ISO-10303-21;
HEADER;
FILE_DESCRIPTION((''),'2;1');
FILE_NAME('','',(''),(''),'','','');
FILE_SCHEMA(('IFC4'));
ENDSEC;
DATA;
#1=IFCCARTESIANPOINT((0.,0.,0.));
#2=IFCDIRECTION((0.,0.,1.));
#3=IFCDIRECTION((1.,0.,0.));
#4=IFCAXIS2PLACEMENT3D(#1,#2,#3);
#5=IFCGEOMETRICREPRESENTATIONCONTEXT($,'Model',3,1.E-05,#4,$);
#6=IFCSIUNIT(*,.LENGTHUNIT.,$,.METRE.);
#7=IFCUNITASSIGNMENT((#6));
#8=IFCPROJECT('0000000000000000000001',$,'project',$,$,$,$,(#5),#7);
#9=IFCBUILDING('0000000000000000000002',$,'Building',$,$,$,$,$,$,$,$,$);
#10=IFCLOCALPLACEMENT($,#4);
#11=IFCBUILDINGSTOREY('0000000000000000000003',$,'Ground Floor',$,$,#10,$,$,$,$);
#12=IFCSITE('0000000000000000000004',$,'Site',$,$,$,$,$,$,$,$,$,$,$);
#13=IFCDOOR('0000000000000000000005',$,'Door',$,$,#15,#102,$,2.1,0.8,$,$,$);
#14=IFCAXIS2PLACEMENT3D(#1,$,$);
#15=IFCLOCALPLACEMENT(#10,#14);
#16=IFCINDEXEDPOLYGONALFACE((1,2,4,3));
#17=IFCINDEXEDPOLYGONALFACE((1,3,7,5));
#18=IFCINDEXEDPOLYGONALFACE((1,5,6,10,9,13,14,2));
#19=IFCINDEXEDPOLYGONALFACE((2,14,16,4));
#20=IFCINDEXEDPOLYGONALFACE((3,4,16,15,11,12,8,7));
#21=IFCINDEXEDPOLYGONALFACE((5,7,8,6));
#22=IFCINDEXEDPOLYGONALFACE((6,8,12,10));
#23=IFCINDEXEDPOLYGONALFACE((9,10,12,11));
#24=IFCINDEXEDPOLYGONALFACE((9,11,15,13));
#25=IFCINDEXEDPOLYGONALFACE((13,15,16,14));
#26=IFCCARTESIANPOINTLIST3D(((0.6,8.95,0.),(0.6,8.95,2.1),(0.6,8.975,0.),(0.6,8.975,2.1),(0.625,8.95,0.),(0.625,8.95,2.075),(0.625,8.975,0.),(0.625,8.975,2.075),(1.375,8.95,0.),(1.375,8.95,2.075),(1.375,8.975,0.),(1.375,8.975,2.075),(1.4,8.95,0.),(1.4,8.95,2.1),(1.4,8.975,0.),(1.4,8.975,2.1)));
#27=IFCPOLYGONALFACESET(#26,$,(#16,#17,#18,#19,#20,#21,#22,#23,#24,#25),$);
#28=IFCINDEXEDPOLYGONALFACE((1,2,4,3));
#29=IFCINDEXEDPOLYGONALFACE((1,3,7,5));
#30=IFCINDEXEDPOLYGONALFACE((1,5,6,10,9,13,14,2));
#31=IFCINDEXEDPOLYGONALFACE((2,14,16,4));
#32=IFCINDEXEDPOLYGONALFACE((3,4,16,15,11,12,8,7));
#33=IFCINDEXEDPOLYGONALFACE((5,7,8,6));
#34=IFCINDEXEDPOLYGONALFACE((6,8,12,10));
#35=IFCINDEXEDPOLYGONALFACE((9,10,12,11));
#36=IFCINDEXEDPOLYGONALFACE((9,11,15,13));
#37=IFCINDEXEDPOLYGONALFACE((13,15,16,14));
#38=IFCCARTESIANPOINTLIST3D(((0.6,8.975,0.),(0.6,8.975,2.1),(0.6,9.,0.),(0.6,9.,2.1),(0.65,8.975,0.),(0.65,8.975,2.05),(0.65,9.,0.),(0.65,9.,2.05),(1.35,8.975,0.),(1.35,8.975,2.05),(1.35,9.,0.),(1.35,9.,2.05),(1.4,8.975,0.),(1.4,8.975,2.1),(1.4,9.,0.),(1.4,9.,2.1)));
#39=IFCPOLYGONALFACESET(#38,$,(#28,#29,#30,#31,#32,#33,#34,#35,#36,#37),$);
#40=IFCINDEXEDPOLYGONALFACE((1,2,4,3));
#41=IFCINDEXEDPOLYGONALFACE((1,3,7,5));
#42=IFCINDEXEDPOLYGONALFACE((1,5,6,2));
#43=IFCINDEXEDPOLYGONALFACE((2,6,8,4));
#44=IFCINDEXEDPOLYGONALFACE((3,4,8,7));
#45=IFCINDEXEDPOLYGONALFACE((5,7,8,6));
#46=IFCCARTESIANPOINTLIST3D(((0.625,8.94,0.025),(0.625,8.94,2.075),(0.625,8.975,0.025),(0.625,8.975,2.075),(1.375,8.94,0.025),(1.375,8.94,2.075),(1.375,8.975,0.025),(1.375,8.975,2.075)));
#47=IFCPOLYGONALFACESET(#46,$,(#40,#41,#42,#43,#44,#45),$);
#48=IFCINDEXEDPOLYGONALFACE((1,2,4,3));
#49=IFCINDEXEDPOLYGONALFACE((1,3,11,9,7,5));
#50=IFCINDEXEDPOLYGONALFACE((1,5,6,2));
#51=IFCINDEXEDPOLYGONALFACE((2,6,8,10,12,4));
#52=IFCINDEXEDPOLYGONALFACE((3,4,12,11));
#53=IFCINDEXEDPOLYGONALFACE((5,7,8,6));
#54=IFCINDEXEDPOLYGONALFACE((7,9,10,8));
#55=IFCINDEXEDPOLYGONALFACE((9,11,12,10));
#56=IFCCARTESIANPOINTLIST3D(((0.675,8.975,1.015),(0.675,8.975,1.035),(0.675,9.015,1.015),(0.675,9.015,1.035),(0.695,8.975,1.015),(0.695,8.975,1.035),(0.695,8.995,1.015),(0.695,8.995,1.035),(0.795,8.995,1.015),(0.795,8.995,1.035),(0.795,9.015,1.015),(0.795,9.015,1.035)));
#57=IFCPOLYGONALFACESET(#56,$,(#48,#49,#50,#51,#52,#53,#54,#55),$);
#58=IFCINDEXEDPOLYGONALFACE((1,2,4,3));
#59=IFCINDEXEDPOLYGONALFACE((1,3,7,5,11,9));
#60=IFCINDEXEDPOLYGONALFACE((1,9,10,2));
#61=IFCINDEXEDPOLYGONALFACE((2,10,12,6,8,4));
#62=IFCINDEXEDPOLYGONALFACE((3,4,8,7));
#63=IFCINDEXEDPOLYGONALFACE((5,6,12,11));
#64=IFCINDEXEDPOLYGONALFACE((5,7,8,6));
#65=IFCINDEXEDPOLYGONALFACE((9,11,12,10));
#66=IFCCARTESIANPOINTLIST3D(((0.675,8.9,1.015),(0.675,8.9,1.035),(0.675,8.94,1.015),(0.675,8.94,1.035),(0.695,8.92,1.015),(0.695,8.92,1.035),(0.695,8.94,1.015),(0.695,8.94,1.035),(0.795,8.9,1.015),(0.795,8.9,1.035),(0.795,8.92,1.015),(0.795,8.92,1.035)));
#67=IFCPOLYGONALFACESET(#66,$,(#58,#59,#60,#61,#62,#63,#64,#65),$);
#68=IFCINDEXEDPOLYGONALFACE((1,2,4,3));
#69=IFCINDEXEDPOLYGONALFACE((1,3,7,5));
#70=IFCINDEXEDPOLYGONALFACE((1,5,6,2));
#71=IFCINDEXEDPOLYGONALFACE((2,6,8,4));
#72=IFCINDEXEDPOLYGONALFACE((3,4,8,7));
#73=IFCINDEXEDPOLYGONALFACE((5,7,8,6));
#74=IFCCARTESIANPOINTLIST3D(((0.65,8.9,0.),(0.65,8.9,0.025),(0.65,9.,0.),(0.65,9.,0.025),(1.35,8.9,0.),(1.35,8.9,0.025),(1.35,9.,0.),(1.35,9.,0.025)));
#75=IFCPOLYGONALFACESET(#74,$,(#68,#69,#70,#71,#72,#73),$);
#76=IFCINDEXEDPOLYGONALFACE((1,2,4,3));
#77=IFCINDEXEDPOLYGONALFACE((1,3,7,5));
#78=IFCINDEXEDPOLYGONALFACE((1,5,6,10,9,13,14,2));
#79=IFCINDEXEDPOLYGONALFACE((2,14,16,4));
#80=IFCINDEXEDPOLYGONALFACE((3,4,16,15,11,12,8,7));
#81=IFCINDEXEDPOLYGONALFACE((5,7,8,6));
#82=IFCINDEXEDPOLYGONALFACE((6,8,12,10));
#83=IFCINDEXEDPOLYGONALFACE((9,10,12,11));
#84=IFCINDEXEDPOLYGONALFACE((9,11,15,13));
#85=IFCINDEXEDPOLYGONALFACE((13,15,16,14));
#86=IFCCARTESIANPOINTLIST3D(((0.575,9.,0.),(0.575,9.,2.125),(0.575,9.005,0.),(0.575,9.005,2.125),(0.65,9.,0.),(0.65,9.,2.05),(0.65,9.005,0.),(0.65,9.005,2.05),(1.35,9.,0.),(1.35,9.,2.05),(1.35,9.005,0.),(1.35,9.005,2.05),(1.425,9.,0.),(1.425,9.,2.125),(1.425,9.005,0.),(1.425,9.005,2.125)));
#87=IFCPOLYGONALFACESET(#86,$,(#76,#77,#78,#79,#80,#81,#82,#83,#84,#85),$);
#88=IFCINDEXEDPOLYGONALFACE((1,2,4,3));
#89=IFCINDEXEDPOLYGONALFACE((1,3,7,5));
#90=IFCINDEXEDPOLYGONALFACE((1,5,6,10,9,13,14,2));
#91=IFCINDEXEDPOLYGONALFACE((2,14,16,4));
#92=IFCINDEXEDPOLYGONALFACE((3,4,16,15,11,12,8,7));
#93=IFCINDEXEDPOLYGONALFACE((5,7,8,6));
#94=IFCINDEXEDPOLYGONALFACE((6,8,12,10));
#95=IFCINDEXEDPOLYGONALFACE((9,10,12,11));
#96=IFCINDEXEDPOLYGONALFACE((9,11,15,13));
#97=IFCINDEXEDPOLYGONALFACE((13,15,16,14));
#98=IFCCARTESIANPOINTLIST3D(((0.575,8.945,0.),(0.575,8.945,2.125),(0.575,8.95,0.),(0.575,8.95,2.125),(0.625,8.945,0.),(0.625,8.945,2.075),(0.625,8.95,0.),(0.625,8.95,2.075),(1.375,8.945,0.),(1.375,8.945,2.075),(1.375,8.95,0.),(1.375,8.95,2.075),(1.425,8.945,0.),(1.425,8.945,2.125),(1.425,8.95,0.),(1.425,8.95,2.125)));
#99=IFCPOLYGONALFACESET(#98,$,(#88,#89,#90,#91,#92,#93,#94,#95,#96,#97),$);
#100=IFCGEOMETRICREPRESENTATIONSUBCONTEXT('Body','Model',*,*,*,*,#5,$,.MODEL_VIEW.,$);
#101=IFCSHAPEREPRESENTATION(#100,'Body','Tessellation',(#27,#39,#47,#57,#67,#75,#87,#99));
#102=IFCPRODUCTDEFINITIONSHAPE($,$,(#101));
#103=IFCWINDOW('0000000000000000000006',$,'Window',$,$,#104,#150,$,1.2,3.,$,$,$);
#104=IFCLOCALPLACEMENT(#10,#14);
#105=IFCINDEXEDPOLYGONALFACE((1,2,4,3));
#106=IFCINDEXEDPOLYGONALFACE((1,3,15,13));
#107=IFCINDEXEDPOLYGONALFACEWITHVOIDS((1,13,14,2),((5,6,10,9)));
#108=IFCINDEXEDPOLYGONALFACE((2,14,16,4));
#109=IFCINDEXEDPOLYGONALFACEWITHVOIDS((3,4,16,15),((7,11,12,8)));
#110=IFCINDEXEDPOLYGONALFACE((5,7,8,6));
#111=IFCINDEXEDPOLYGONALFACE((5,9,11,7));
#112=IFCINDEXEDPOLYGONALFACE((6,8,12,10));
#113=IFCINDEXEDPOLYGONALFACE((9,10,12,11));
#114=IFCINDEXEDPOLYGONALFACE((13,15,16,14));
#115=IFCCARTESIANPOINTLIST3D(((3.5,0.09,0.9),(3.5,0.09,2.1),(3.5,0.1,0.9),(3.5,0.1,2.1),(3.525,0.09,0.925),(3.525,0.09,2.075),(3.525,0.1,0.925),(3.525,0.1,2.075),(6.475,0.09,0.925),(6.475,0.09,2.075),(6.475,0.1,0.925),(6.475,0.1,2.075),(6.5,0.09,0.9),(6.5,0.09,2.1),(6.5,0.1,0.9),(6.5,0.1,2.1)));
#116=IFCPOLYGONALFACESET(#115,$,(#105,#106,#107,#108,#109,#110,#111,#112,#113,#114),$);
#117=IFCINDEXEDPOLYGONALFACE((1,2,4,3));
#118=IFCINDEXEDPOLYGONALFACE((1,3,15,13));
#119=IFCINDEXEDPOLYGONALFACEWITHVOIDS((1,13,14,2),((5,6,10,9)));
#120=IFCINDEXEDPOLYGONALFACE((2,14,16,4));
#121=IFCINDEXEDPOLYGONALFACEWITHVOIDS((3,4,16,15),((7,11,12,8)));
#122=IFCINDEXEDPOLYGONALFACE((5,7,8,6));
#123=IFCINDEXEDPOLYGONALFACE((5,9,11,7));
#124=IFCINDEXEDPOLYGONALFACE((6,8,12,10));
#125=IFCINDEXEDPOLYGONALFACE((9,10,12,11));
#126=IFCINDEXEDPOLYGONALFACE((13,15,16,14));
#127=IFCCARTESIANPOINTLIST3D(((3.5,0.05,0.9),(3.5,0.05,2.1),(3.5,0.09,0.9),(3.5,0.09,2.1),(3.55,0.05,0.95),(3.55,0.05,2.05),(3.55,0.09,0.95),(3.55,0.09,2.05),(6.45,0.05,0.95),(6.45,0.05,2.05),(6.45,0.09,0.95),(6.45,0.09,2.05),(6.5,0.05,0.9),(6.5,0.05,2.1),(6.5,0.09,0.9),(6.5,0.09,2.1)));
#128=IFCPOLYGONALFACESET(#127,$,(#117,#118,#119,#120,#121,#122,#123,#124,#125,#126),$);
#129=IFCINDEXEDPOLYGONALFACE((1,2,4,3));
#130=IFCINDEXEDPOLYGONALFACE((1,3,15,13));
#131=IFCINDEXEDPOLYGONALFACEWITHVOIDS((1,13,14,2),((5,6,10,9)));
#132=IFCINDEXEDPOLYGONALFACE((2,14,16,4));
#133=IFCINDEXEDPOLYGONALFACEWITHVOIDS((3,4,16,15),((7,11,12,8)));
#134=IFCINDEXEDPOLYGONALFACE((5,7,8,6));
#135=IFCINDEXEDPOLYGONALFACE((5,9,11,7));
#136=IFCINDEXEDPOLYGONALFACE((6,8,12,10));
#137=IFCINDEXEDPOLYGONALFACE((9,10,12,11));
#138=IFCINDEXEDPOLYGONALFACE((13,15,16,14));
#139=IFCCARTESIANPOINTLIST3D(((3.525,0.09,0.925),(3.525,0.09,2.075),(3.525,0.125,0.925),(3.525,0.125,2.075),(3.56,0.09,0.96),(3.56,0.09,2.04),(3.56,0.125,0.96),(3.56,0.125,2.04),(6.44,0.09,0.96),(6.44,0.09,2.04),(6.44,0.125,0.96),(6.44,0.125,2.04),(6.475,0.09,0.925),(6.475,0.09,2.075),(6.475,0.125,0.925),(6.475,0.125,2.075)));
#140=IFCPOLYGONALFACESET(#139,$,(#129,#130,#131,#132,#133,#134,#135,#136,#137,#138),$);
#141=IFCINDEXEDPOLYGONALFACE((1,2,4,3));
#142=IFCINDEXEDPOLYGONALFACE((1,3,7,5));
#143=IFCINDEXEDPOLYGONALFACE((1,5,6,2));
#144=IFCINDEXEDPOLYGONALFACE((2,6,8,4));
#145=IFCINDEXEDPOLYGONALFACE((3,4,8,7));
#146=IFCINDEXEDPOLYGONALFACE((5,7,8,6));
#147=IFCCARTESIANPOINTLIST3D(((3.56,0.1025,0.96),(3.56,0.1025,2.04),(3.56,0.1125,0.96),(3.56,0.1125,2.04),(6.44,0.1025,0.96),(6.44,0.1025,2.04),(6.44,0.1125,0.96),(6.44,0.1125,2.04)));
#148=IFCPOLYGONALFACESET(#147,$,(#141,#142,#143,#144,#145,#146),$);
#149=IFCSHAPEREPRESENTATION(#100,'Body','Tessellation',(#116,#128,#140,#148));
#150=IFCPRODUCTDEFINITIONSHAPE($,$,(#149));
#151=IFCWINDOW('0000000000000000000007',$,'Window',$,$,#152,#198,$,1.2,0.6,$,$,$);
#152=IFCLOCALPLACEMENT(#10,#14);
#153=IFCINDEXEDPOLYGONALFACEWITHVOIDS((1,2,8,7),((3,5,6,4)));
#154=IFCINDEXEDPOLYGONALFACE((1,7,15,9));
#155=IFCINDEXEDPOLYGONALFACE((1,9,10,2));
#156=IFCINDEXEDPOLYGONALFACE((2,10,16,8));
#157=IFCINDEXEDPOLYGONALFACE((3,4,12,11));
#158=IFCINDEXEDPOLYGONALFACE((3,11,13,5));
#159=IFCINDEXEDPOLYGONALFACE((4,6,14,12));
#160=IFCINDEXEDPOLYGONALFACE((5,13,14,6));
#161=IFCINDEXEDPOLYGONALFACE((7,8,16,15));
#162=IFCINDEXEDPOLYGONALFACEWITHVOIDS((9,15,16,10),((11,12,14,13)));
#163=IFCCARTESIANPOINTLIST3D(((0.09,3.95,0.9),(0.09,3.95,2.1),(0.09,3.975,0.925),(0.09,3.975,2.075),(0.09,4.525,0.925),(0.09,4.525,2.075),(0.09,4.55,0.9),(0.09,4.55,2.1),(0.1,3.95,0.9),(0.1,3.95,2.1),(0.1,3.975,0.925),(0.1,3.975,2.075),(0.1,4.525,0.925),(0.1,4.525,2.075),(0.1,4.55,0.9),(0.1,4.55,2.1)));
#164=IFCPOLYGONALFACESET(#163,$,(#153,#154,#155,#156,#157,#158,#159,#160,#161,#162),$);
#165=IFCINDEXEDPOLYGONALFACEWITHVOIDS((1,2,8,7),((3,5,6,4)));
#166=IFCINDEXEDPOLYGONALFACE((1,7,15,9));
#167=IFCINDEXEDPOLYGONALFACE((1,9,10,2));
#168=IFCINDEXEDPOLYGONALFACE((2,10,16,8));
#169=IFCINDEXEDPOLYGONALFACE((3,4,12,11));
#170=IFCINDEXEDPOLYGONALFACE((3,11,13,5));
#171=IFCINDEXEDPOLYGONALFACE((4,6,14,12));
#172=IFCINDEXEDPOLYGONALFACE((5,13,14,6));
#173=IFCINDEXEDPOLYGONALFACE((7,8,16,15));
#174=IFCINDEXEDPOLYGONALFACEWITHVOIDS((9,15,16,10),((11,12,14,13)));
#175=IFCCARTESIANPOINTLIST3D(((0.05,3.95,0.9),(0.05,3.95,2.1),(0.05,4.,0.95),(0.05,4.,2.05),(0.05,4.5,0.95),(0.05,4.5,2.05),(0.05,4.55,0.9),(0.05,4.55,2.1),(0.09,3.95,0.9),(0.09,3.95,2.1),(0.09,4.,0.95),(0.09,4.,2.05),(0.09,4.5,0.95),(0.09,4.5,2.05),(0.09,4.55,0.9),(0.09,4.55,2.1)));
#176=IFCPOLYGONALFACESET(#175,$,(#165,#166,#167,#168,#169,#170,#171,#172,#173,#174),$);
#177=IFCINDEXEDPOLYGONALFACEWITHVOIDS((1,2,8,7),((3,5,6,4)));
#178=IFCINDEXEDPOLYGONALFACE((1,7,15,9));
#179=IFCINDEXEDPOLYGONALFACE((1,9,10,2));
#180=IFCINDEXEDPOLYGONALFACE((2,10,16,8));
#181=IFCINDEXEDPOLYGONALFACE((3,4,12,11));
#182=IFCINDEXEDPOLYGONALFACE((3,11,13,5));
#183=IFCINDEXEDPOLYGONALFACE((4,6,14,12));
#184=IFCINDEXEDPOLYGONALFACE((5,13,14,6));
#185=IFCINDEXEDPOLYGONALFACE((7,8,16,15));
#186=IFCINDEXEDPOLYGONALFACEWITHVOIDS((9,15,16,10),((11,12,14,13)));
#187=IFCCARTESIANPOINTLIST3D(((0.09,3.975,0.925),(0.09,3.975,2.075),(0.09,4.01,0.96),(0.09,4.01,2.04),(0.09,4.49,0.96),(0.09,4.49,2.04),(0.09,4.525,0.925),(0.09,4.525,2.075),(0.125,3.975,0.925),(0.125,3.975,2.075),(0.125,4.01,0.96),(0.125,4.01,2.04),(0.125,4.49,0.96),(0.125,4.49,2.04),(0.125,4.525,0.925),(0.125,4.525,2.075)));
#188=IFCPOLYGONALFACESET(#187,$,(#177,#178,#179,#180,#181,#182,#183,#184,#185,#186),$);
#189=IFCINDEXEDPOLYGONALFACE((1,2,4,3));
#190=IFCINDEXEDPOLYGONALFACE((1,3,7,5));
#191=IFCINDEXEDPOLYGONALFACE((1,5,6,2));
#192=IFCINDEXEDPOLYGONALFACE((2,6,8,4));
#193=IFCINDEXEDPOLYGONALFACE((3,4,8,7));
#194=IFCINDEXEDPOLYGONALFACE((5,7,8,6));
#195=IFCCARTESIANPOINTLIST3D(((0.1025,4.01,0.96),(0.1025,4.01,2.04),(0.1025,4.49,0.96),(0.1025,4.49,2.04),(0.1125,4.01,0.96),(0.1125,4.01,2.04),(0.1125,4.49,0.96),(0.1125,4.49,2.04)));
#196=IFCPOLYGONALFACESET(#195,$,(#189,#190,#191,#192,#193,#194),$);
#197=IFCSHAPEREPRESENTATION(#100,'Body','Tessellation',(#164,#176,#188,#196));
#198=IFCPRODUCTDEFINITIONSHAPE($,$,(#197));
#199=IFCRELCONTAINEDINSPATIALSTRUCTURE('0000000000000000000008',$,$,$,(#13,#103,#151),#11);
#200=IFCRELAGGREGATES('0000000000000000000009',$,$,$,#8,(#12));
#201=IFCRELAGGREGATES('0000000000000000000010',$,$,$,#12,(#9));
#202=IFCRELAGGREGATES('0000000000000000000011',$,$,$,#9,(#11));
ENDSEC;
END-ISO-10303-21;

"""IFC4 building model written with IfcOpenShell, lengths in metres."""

from ifc_helpers import new_model, si_unit, frame, origin_with_axes, place, context, subcontext, project, spatial, line, indexed_curve, outline, extrude, element, save


model = new_model("IFC4")

# Units and contexts
model_context = context("Model", 3, precision=1e-05, world=origin_with_axes())
body_context = subcontext(model_context, "Body", "Model", "MODEL_VIEW")
ifc_project = project(units=[si_unit("LENGTHUNIT", "METRE")], contexts=[model_context])

# Site, building, storey
site = spatial("IfcSite", under=ifc_project, Name="Site")
building = spatial("IfcBuilding", under=site, Name="Building")
storey_placement = place(None, origin_with_axes())
storey = spatial("IfcBuildingStorey", under=building, at=storey_placement, Name="Ground Floor")

# Door
door_1_placement = place(storey_placement, frame((1.4, 9.0, 0.0), z_axis=(0.0, 0.0, 1.0), x_axis=(-1.0, 0.0, 0.0)))
element("IfcDoor", 1, at=door_1_placement, inside=storey, Name="Door", OverallHeight=2.1, OverallWidth=0.8, context=body_context, shape_type="SweptSolid", body=[
    extrude(outline(indexed_curve([(0.0, 0.0), (0.0, 2.1), (0.8, 2.1), (0.8, 0.0), (0.775, 0.0), (0.775, 2.075), (0.025, 2.075), (0.025, 0.0)], segments=[line(1, 2, 3, 4, 5, 6, 7, 8, 1)])), frame((0.0, 0.025, 0.0), z_axis=(0.0, -1.0, 0.0), x_axis=(1.0, 0.0, 0.0)), (0.0, 0.0, -1.0), 0.025),
    extrude(outline(indexed_curve([(0.0, 0.0), (0.0, 2.1), (0.8, 2.1), (0.8, 0.0), (0.75, 0.0), (0.75, 2.05), (0.05, 2.05), (0.05, 0.0)], segments=[line(1, 2, 3, 4, 5, 6, 7, 8, 1)])), frame((0.0, 0.0, 0.0), z_axis=(0.0, -1.0, 0.0), x_axis=(1.0, 0.0, 0.0)), (0.0, 0.0, -1.0), 0.025),
    extrude(outline(indexed_curve([(0.0, 0.0), (0.75, 0.0), (0.75, 0.035), (0.0, 0.035)], segments=[line(1, 2, 3, 4, 1)])), frame((0.025, 0.025, 0.025), z_axis=(0.0, 0.0, 1.0), x_axis=(1.0, 0.0, 0.0)), (0.0, 0.0, 1.0), 2.05),
    extrude(outline(indexed_curve([(0.0, 0.0), (0.0, -0.04), (-0.12, -0.04), (-0.12, -0.02), (-0.02, -0.02), (-0.02, 0.0)], segments=[line(1, 2, 3, 4, 5, 6, 1)])), frame((0.725, 0.025, 1.015), z_axis=(0.0, 0.0, 1.0), x_axis=(1.0, 0.0, 0.0)), (0.0, 0.0, 1.0), 0.02),
    extrude(outline(indexed_curve([(0.0, 0.0), (0.0, 0.04), (-0.12, 0.04), (-0.12, 0.02), (-0.02, 0.02), (-0.02, 0.0)], segments=[line(1, 2, 3, 4, 5, 6, 1)])), frame((0.725, 0.06, 1.015), z_axis=(0.0, 0.0, 1.0), x_axis=(1.0, 0.0, 0.0)), (0.0, 0.0, 1.0), 0.02),
    extrude(outline(indexed_curve([(0.0, 0.0), (0.7, 0.0), (0.7, 0.1), (0.0, 0.1)], segments=[line(1, 2, 3, 4, 1)])), frame((0.05, 0.0, 0.0), z_axis=(0.0, 0.0, 1.0), x_axis=(1.0, 0.0, 0.0)), (0.0, 0.0, 1.0), 0.025),
    extrude(outline(indexed_curve([(0.0, 0.0), (0.0, 2.125), (0.85, 2.125), (0.85, 0.0), (0.775, 0.0), (0.775, 2.05), (0.075, 2.05), (0.075, 0.0)], segments=[line(1, 2, 3, 4, 5, 6, 7, 8, 1)])), frame((-0.025, -0.005, 0.0), z_axis=(0.0, -1.0, 0.0), x_axis=(1.0, 0.0, 0.0)), (0.0, 0.0, -1.0), 0.005),
    extrude(outline(indexed_curve([(0.0, 0.0), (0.0, 2.125), (0.85, 2.125), (0.85, 0.0), (0.8, 0.0), (0.8, 2.075), (0.05, 2.075), (0.05, 0.0)], segments=[line(1, 2, 3, 4, 5, 6, 7, 8, 1)])), frame((-0.025, 0.05, 0.0), z_axis=(0.0, -1.0, 0.0), x_axis=(1.0, 0.0, 0.0)), (0.0, 0.0, -1.0), 0.005),
])

# Windows
window_1_placement = place(storey_placement, frame((3.5, 0.0, 0.9), z_axis=(0.0, 0.0, 1.0), x_axis=(1.0, 0.0, 0.0)))
element("IfcWindow", 2, at=window_1_placement, inside=storey, Name="Window", OverallHeight=1.2, OverallWidth=3.0, context=body_context, shape_type="SweptSolid", body=[
    extrude(outline(indexed_curve([(0.0, 0.0), (3.0, 0.0), (3.0, 1.2), (0.0, 1.2)], segments=[line(1, 2, 3, 4, 1)]), holes=[indexed_curve([(0.025, 0.025), (2.975, 0.025), (2.975, 1.175), (0.025, 1.175)], segments=[line(1, 2, 3, 4, 1)])]), frame((0.0, 0.09, 0.0), z_axis=(0.0, -1.0, 0.0), x_axis=(1.0, 0.0, 0.0)), (0.0, 0.0, -1.0), 0.01),
    extrude(outline(indexed_curve([(0.0, 0.0), (3.0, 0.0), (3.0, 1.2), (0.0, 1.2)], segments=[line(1, 2, 3, 4, 1)]), holes=[indexed_curve([(0.05, 0.05), (2.95, 0.05), (2.95, 1.15), (0.05, 1.15)], segments=[line(1, 2, 3, 4, 1)])]), frame((0.0, 0.05, 0.0), z_axis=(0.0, -1.0, 0.0), x_axis=(1.0, 0.0, 0.0)), (0.0, 0.0, -1.0), 0.04),
    extrude(outline(indexed_curve([(0.0, 0.0), (2.95, 0.0), (2.95, 1.15), (0.0, 1.15)], segments=[line(1, 2, 3, 4, 1)]), holes=[indexed_curve([(0.035, 0.035), (2.915, 0.035), (2.915, 1.115), (0.035, 1.115)], segments=[line(1, 2, 3, 4, 1)])]), frame((0.025, 0.09, 0.025), z_axis=(0.0, -1.0, 0.0), x_axis=(1.0, 0.0, 0.0)), (0.0, 0.0, -1.0), 0.035),
    extrude(outline(indexed_curve([(0.035, 0.035), (2.915, 0.035), (2.915, 1.115), (0.035, 1.115)], segments=[line(1, 2, 3, 4, 1)])), frame((0.025, 0.1025, 0.025), z_axis=(0.0, -1.0, 0.0), x_axis=(1.0, 0.0, 0.0)), (0.0, 0.0, -1.0), 0.01),
])
window_2_placement = place(storey_placement, frame((0.0, 4.55, 0.9), z_axis=(0.0, 0.0, 1.0), x_axis=(0.0, -1.0, 0.0)))
element("IfcWindow", 3, at=window_2_placement, inside=storey, Name="Window", OverallHeight=1.2, OverallWidth=0.6, context=body_context, shape_type="SweptSolid", body=[
    extrude(outline(indexed_curve([(0.0, 0.0), (0.6, 0.0), (0.6, 1.2), (0.0, 1.2)], segments=[line(1, 2, 3, 4, 1)]), holes=[indexed_curve([(0.025, 0.025), (0.575, 0.025), (0.575, 1.175), (0.025, 1.175)], segments=[line(1, 2, 3, 4, 1)])]), frame((0.0, 0.09, 0.0), z_axis=(0.0, -1.0, 0.0), x_axis=(1.0, 0.0, 0.0)), (0.0, 0.0, -1.0), 0.01),
    extrude(outline(indexed_curve([(0.0, 0.0), (0.6, 0.0), (0.6, 1.2), (0.0, 1.2)], segments=[line(1, 2, 3, 4, 1)]), holes=[indexed_curve([(0.05, 0.05), (0.55, 0.05), (0.55, 1.15), (0.05, 1.15)], segments=[line(1, 2, 3, 4, 1)])]), frame((0.0, 0.05, 0.0), z_axis=(0.0, -1.0, 0.0), x_axis=(1.0, 0.0, 0.0)), (0.0, 0.0, -1.0), 0.04),
    extrude(outline(indexed_curve([(0.0, 0.0), (0.55, 0.0), (0.55, 1.15), (0.0, 1.15)], segments=[line(1, 2, 3, 4, 1)]), holes=[indexed_curve([(0.035, 0.035), (0.515, 0.035), (0.515, 1.115), (0.035, 1.115)], segments=[line(1, 2, 3, 4, 1)])]), frame((0.025, 0.09, 0.025), z_axis=(0.0, -1.0, 0.0), x_axis=(1.0, 0.0, 0.0)), (0.0, 0.0, -1.0), 0.035),
    extrude(outline(indexed_curve([(0.035, 0.035), (0.515, 0.035), (0.515, 1.115), (0.035, 1.115)], segments=[line(1, 2, 3, 4, 1)])), frame((0.025, 0.1025, 0.025), z_axis=(0.0, -1.0, 0.0), x_axis=(1.0, 0.0, 0.0)), (0.0, 0.0, -1.0), 0.01),
])

save(model, "model.ifc")
